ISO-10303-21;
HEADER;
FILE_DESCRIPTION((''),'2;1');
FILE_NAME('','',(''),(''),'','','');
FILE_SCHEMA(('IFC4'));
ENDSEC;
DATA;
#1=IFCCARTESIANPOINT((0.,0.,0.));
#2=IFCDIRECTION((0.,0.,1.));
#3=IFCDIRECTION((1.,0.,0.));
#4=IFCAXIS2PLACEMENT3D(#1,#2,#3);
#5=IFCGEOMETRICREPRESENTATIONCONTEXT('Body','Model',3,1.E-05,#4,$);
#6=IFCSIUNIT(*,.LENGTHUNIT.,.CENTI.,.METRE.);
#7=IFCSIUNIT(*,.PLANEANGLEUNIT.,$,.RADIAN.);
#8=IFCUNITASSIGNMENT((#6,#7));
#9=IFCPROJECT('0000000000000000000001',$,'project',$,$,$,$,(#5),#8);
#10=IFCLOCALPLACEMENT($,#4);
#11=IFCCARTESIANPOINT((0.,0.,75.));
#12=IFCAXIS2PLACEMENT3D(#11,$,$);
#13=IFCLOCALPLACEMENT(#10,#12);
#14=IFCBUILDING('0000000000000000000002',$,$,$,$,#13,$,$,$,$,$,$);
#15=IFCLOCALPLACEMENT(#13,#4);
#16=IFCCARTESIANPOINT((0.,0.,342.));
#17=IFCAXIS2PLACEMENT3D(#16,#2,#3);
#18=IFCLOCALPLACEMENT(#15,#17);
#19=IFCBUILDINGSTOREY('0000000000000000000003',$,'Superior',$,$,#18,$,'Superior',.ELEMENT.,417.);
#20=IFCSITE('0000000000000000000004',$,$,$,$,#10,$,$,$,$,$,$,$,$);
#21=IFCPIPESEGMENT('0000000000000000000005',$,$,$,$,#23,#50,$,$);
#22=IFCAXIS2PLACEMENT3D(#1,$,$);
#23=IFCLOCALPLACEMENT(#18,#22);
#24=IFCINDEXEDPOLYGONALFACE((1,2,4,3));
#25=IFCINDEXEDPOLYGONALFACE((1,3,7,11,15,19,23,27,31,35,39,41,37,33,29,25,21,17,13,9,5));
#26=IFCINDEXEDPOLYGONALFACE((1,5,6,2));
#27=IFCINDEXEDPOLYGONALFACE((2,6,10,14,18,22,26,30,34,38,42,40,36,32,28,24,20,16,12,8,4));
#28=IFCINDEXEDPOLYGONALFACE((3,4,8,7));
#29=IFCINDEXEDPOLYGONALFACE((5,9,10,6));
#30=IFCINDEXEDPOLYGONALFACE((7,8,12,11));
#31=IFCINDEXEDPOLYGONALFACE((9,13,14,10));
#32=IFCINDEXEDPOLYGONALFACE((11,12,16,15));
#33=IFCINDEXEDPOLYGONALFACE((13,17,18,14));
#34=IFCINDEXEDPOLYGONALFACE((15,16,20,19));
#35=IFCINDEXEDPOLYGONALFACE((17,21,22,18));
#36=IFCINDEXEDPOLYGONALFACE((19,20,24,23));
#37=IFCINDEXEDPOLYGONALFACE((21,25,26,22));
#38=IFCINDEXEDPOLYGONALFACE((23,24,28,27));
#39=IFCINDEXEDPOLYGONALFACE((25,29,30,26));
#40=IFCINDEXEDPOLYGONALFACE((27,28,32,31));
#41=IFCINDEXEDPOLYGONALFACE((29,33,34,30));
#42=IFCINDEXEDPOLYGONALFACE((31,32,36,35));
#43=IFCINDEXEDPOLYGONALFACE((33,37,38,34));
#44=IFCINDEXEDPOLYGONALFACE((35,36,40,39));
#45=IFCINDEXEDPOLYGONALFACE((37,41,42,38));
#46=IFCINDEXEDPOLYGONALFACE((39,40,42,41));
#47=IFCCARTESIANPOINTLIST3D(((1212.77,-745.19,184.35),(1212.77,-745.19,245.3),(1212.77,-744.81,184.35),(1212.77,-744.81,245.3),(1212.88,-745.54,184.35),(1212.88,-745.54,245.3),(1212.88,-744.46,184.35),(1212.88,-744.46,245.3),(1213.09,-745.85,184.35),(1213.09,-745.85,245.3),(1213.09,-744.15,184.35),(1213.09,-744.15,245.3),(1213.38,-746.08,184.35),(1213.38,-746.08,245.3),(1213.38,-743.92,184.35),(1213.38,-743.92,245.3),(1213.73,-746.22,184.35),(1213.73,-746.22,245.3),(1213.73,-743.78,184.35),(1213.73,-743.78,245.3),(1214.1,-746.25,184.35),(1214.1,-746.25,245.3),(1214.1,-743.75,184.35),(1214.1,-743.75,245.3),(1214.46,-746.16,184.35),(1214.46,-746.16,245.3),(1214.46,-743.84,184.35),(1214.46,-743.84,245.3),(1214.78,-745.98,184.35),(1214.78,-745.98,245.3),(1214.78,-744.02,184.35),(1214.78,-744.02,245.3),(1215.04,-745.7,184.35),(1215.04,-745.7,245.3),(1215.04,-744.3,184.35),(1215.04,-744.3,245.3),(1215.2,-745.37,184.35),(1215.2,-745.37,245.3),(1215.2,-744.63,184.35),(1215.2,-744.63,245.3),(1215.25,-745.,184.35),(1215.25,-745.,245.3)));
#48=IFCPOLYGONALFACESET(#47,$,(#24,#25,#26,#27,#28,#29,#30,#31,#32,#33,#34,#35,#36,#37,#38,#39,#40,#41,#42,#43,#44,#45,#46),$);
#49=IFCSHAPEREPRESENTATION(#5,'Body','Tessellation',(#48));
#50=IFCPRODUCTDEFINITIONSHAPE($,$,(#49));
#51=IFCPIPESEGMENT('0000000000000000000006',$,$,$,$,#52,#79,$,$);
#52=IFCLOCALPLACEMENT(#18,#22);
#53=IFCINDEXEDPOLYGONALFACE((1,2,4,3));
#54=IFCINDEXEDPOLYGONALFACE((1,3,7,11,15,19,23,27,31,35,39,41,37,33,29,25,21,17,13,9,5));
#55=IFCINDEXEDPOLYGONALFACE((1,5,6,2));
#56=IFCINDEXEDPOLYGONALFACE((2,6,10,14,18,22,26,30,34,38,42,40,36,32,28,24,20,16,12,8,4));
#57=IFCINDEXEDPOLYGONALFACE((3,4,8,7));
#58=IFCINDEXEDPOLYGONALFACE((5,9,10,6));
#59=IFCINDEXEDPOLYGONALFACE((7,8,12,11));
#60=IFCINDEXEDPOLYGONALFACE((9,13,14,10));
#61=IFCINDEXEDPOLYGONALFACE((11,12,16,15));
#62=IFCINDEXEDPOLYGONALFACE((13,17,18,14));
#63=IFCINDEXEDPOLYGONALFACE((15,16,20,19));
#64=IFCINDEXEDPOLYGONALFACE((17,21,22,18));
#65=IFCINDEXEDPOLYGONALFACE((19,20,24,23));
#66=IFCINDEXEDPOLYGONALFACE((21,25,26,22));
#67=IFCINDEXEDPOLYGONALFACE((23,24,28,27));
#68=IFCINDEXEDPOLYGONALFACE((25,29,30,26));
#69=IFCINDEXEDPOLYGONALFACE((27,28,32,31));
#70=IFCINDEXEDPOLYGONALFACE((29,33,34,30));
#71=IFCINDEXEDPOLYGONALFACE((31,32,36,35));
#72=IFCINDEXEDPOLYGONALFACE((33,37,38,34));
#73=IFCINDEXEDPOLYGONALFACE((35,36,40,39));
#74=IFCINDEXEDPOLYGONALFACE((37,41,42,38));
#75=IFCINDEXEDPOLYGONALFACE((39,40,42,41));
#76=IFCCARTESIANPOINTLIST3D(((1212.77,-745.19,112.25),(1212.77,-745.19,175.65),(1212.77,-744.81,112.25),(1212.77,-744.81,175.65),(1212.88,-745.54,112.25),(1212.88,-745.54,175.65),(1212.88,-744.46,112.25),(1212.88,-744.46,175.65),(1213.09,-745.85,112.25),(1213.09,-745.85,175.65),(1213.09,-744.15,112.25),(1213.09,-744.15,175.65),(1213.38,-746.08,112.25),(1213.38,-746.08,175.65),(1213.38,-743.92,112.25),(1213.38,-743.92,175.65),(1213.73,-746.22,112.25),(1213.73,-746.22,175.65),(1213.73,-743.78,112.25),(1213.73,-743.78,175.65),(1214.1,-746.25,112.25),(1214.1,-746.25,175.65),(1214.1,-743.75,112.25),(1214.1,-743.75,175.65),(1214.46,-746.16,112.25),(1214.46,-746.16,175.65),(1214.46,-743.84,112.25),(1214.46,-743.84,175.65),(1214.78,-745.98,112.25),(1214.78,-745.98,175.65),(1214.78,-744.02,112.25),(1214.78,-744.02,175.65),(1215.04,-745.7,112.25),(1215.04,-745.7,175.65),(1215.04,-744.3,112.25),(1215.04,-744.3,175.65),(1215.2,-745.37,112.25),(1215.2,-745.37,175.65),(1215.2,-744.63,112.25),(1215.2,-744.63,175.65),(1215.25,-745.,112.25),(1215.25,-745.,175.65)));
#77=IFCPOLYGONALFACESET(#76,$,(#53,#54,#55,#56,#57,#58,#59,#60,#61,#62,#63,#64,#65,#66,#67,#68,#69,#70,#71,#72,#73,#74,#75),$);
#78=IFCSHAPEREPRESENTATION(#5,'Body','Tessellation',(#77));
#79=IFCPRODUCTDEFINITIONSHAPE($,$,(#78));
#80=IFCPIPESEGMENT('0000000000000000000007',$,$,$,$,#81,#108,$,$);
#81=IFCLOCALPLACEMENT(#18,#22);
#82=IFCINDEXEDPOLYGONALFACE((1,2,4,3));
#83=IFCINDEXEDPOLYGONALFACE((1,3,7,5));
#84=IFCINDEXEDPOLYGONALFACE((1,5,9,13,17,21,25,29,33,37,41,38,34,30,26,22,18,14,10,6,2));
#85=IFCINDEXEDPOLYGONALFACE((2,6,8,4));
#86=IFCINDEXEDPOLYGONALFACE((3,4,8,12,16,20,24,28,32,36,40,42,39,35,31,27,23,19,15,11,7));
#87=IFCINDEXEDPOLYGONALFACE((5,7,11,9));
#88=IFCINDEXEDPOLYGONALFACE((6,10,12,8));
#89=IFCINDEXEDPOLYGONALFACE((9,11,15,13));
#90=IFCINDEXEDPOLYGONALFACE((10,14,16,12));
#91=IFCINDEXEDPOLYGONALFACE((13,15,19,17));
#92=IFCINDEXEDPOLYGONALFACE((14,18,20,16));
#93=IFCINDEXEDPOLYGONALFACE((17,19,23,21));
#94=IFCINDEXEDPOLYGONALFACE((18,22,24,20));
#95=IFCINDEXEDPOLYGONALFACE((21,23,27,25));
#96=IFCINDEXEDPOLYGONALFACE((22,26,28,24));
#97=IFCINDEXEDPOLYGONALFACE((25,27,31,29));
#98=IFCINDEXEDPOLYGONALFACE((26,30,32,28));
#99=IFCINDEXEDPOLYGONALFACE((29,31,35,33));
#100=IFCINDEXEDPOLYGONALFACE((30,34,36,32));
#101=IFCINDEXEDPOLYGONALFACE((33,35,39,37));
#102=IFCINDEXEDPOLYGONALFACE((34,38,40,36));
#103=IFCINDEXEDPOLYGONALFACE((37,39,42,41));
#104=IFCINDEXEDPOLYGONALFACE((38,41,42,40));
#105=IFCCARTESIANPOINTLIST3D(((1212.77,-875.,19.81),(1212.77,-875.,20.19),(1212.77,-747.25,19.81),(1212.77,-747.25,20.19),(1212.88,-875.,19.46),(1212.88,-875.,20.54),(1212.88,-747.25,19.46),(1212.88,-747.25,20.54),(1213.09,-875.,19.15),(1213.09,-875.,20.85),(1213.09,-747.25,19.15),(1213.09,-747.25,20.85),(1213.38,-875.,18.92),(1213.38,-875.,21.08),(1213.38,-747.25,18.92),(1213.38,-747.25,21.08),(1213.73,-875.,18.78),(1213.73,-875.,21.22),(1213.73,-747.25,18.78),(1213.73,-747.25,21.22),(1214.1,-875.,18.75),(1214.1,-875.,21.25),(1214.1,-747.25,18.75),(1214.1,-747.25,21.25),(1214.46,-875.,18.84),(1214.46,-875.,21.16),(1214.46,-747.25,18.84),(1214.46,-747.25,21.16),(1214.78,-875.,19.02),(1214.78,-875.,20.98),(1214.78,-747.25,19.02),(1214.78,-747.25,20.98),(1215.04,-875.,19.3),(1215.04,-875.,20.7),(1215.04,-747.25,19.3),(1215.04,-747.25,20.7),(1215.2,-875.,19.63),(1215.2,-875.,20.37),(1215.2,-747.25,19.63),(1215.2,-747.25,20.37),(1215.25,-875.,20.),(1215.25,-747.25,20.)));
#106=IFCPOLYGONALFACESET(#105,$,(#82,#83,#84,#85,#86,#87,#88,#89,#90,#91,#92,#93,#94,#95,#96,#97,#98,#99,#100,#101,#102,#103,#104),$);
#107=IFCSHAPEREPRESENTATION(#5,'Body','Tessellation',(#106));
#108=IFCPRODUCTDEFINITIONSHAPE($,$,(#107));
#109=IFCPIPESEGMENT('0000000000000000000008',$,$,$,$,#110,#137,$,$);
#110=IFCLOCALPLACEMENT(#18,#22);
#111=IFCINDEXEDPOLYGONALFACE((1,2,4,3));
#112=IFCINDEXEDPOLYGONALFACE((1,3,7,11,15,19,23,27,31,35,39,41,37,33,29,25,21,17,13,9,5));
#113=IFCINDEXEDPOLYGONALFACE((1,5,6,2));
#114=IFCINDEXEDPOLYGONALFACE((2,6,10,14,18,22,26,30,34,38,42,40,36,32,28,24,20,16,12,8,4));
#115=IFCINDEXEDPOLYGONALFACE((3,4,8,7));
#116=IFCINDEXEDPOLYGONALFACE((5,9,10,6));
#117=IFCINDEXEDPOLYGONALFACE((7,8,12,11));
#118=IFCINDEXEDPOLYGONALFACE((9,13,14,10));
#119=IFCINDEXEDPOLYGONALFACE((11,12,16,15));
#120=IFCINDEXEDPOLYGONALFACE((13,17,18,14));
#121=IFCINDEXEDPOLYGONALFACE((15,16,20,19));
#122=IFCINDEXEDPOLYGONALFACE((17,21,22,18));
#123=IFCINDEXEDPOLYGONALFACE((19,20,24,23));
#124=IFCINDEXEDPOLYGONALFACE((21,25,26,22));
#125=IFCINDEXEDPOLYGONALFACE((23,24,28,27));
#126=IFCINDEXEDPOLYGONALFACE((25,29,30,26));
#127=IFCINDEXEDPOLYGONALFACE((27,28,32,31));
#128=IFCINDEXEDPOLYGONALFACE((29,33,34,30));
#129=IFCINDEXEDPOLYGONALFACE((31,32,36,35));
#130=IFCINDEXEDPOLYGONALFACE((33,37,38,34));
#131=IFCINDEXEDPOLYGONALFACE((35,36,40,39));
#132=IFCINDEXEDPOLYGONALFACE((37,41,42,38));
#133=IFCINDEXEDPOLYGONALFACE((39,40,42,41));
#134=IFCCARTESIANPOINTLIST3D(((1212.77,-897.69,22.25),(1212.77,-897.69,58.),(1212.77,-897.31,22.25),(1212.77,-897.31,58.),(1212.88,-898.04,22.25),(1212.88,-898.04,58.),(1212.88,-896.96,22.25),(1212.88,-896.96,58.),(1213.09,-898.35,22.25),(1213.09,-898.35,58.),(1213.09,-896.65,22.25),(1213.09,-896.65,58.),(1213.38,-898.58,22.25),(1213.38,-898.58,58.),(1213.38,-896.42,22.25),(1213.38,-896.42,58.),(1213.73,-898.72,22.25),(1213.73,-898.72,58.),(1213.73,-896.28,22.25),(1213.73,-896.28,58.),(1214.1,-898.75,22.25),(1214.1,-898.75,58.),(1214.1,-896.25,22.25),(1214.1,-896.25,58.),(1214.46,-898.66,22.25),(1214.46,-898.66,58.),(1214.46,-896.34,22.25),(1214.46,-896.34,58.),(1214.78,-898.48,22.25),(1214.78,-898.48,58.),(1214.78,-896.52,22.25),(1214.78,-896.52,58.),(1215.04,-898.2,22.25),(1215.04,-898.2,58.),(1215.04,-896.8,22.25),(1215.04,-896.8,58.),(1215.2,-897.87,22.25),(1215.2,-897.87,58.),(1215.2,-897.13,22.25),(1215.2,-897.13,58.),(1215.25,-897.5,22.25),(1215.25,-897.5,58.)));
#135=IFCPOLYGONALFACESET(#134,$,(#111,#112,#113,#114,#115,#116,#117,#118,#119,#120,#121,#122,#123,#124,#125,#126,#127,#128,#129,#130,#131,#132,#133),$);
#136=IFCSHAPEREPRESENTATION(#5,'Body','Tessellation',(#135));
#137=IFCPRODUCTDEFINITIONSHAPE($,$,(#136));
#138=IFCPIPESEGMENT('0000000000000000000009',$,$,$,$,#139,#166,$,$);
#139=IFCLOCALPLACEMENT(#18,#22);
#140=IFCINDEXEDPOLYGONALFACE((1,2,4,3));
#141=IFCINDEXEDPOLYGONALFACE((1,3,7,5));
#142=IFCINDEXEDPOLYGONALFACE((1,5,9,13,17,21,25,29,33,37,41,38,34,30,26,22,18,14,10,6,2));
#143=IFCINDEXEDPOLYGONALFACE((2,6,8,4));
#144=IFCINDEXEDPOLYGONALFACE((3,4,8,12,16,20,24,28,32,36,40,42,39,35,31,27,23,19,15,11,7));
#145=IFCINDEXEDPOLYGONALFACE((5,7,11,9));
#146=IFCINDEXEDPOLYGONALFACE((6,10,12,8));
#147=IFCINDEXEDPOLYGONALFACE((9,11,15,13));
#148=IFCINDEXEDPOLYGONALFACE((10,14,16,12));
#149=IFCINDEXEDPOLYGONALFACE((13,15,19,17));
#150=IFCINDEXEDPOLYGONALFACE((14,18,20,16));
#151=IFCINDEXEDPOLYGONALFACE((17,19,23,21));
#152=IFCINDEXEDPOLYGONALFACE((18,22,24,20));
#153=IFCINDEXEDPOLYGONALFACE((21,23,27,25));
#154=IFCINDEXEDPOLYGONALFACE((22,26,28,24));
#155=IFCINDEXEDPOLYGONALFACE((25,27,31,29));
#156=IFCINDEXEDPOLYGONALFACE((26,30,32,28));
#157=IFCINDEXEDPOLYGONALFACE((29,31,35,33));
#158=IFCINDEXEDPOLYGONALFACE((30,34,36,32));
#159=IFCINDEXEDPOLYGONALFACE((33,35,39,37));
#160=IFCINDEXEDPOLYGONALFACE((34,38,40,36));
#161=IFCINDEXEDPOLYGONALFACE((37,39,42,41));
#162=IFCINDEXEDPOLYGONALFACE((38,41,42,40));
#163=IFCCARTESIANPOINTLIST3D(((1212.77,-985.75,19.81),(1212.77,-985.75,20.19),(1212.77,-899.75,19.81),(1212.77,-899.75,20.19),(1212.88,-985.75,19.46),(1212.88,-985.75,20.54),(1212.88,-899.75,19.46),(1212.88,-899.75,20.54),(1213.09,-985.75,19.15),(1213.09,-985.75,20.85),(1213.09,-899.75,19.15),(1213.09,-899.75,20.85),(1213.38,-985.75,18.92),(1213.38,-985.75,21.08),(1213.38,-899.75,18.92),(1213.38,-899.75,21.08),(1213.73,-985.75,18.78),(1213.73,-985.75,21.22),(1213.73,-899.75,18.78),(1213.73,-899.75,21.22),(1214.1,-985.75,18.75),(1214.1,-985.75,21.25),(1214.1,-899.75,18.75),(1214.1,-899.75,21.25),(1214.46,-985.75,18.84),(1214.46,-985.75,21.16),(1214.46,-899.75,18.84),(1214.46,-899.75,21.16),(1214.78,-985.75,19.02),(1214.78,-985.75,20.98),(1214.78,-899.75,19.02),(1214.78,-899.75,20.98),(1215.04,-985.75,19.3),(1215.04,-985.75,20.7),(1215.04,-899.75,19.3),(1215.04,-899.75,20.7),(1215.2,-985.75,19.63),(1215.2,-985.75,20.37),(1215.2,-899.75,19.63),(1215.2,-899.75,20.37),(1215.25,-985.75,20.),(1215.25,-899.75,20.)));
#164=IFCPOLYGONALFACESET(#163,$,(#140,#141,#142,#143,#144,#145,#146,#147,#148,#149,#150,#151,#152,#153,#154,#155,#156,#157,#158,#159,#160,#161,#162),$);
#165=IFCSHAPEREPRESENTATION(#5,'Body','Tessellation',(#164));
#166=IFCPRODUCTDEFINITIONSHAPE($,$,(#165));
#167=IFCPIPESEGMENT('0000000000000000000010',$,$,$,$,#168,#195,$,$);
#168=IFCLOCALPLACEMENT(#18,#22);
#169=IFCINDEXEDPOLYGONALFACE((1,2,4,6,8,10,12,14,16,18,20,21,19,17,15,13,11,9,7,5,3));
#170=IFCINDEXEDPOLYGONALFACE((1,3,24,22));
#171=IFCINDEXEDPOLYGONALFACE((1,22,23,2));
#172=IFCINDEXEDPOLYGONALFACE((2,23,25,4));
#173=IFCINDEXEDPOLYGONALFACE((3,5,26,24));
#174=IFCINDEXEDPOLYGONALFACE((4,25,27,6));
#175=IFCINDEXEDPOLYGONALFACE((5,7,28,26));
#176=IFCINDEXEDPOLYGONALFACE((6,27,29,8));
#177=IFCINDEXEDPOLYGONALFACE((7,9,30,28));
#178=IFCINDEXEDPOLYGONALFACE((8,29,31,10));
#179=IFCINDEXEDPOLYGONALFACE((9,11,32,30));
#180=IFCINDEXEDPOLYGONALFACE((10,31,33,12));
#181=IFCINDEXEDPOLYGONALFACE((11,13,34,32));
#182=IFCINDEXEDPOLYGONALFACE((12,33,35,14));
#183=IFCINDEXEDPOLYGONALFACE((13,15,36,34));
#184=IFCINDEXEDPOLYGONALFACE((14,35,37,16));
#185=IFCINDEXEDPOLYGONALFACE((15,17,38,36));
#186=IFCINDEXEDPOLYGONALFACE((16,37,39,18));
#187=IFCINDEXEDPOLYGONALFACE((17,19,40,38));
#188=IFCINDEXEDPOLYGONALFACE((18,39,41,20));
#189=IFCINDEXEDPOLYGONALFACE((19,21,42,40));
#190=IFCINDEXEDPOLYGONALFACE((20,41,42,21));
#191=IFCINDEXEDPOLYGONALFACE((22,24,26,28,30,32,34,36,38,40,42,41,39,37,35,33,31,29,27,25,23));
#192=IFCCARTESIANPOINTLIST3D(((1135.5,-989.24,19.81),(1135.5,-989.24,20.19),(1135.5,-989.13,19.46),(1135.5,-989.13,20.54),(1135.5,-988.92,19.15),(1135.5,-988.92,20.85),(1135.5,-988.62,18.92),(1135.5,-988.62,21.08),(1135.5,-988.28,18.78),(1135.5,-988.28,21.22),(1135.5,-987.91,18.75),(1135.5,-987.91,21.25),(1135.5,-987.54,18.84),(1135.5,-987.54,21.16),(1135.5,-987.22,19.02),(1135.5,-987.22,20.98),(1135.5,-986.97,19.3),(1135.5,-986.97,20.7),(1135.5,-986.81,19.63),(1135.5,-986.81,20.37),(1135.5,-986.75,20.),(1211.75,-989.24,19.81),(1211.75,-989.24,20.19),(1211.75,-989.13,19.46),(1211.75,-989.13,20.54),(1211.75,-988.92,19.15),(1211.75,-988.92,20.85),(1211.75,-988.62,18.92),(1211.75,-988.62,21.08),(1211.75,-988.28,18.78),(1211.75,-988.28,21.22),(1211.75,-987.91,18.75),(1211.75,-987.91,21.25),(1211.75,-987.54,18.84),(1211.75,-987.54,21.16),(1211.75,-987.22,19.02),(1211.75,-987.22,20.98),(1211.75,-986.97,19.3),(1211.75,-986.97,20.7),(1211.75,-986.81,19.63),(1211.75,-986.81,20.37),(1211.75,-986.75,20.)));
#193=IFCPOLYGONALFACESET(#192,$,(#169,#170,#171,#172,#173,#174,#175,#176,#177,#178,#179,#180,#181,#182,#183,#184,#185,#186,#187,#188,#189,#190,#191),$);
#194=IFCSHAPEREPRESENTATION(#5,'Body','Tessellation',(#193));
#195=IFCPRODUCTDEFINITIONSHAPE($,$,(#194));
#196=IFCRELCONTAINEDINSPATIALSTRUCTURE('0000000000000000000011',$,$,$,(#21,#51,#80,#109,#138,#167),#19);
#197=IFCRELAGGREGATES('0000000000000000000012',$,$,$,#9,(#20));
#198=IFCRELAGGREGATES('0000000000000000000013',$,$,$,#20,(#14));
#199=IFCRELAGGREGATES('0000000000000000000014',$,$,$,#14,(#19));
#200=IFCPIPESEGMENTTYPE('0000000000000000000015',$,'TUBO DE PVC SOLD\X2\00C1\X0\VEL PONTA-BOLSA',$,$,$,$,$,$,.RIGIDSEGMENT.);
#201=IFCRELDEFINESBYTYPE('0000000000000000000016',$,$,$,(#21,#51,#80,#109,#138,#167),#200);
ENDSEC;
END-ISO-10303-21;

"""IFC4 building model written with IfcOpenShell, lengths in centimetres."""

from ifc_helpers import new_model, si_unit, frame, origin_with_axes, origin_2d_with_axis, place, context, project, spatial, circle, extrude, type_object, element, save


model = new_model("IFC4")

# Units and contexts
model_context = context("Model", 3, precision=1e-05, world=origin_with_axes(), identifier="Body")
ifc_project = project(units=[si_unit("LENGTHUNIT", "METRE", prefix="CENTI"), si_unit("PLANEANGLEUNIT", "RADIAN")], contexts=[model_context])

# Site, building, storey
site_placement = place(None, origin_with_axes())
site = spatial("IfcSite", under=ifc_project, at=site_placement)
building_placement = place(site_placement, frame((0.0, 0.0, 75.0)))
building = spatial("IfcBuilding", under=site, at=building_placement)
placement = place(building_placement, origin_with_axes())
storey_placement = place(placement, frame((0.0, 0.0, 342.0), z_axis=(0.0, 0.0, 1.0), x_axis=(1.0, 0.0, 0.0)))
storey = spatial("IfcBuildingStorey", under=building, at=storey_placement, Name="Superior", LongName="Superior", CompositionType="ELEMENT", Elevation=417.0)

# Pipe segments
pipe_segment_type_1 = type_object("IfcPipeSegmentType", Name="TUBO DE PVC SOLDÁVEL PONTA-BOLSA", PredefinedType="RIGIDSEGMENT")
pipe_segment_1_placement = place(storey_placement, frame((1214.0, -745.0, 245.3), z_axis=(0.0, 0.0, 1.0), x_axis=(1.0, 0.0, 0.0)))
element("IfcPipeSegment", 1, at=pipe_segment_1_placement, inside=storey, type_object=pipe_segment_type_1, context=model_context, shape_type="SolidModel", body=[
    extrude(circle(Radius=1.25, at=origin_2d_with_axis()), frame((0.0, 0.0, 0.0), z_axis=(0.0, 0.0, -1.0), x_axis=(1.0, 0.0, 0.0)), (0.0, 0.0, 1.0), 60.95),
])
pipe_segment_2_placement = place(storey_placement, frame((1214.0, -745.0, 175.65), z_axis=(0.0, 0.0, 1.0), x_axis=(1.0, 0.0, 0.0)))
element("IfcPipeSegment", 2, at=pipe_segment_2_placement, inside=storey, type_object=pipe_segment_type_1, context=model_context, shape_type="SolidModel", body=[
    extrude(circle(Radius=1.25, at=origin_2d_with_axis()), frame((0.0, 0.0, 0.0), z_axis=(0.0, 0.0, -1.0), x_axis=(1.0, 0.0, 0.0)), (0.0, 0.0, 1.0), 63.4),
])
pipe_segment_3_placement = place(storey_placement, frame((1214.0, -811.12, 21.25), z_axis=(0.0, 0.0, 1.0), x_axis=(1.0, 0.0, 0.0)))
element("IfcPipeSegment", 3, at=pipe_segment_3_placement, inside=storey, type_object=pipe_segment_type_1, context=model_context, shape_type="SolidModel", body=[
    extrude(circle(Radius=1.25, at=origin_2d_with_axis()), frame((0.0, 63.88, -1.25), z_axis=(0.0, -1.0, 0.0), x_axis=(1.0, 0.0, 0.0)), (0.0, 0.0, 1.0), 127.75),
])
pipe_segment_4_placement = place(storey_placement, frame((1214.0, -897.5, 58.0), z_axis=(0.0, 0.0, 1.0), x_axis=(1.0, 0.0, 0.0)))
element("IfcPipeSegment", 4, at=pipe_segment_4_placement, inside=storey, type_object=pipe_segment_type_1, context=model_context, shape_type="SolidModel", body=[
    extrude(circle(Radius=1.25, at=origin_2d_with_axis()), frame((0.0, 0.0, -35.75), z_axis=(0.0, 0.0, 1.0), x_axis=(1.0, 0.0, 0.0)), (0.0, 0.0, 1.0), 35.75),
])
pipe_segment_5_placement = place(storey_placement, frame((1214.0, -942.75, 21.25), z_axis=(0.0, 0.0, 1.0), x_axis=(1.0, 0.0, 0.0)))
element("IfcPipeSegment", 5, at=pipe_segment_5_placement, inside=storey, type_object=pipe_segment_type_1, context=model_context, shape_type="SolidModel", body=[
    extrude(circle(Radius=1.25, at=origin_2d_with_axis()), frame((0.0, 43.0, -1.25), z_axis=(0.0, -1.0, 0.0), x_axis=(1.0, 0.0, 0.0)), (0.0, 0.0, 1.0), 86.0),
])
pipe_segment_6_placement = place(storey_placement, frame((1173.63, -988.0, 21.25), z_axis=(0.0, 0.0, 1.0), x_axis=(1.0, 0.0, 0.0)))
element("IfcPipeSegment", 6, at=pipe_segment_6_placement, inside=storey, type_object=pipe_segment_type_1, context=model_context, shape_type="SolidModel", body=[
    extrude(circle(Radius=1.25, at=origin_2d_with_axis()), frame((38.12, 0.0, -1.25), z_axis=(-1.0, 0.0, 0.0), x_axis=(0.0, 1.0, 0.0)), (0.0, 0.0, 1.0), 76.25),
])

save(model, "model.ifc")
